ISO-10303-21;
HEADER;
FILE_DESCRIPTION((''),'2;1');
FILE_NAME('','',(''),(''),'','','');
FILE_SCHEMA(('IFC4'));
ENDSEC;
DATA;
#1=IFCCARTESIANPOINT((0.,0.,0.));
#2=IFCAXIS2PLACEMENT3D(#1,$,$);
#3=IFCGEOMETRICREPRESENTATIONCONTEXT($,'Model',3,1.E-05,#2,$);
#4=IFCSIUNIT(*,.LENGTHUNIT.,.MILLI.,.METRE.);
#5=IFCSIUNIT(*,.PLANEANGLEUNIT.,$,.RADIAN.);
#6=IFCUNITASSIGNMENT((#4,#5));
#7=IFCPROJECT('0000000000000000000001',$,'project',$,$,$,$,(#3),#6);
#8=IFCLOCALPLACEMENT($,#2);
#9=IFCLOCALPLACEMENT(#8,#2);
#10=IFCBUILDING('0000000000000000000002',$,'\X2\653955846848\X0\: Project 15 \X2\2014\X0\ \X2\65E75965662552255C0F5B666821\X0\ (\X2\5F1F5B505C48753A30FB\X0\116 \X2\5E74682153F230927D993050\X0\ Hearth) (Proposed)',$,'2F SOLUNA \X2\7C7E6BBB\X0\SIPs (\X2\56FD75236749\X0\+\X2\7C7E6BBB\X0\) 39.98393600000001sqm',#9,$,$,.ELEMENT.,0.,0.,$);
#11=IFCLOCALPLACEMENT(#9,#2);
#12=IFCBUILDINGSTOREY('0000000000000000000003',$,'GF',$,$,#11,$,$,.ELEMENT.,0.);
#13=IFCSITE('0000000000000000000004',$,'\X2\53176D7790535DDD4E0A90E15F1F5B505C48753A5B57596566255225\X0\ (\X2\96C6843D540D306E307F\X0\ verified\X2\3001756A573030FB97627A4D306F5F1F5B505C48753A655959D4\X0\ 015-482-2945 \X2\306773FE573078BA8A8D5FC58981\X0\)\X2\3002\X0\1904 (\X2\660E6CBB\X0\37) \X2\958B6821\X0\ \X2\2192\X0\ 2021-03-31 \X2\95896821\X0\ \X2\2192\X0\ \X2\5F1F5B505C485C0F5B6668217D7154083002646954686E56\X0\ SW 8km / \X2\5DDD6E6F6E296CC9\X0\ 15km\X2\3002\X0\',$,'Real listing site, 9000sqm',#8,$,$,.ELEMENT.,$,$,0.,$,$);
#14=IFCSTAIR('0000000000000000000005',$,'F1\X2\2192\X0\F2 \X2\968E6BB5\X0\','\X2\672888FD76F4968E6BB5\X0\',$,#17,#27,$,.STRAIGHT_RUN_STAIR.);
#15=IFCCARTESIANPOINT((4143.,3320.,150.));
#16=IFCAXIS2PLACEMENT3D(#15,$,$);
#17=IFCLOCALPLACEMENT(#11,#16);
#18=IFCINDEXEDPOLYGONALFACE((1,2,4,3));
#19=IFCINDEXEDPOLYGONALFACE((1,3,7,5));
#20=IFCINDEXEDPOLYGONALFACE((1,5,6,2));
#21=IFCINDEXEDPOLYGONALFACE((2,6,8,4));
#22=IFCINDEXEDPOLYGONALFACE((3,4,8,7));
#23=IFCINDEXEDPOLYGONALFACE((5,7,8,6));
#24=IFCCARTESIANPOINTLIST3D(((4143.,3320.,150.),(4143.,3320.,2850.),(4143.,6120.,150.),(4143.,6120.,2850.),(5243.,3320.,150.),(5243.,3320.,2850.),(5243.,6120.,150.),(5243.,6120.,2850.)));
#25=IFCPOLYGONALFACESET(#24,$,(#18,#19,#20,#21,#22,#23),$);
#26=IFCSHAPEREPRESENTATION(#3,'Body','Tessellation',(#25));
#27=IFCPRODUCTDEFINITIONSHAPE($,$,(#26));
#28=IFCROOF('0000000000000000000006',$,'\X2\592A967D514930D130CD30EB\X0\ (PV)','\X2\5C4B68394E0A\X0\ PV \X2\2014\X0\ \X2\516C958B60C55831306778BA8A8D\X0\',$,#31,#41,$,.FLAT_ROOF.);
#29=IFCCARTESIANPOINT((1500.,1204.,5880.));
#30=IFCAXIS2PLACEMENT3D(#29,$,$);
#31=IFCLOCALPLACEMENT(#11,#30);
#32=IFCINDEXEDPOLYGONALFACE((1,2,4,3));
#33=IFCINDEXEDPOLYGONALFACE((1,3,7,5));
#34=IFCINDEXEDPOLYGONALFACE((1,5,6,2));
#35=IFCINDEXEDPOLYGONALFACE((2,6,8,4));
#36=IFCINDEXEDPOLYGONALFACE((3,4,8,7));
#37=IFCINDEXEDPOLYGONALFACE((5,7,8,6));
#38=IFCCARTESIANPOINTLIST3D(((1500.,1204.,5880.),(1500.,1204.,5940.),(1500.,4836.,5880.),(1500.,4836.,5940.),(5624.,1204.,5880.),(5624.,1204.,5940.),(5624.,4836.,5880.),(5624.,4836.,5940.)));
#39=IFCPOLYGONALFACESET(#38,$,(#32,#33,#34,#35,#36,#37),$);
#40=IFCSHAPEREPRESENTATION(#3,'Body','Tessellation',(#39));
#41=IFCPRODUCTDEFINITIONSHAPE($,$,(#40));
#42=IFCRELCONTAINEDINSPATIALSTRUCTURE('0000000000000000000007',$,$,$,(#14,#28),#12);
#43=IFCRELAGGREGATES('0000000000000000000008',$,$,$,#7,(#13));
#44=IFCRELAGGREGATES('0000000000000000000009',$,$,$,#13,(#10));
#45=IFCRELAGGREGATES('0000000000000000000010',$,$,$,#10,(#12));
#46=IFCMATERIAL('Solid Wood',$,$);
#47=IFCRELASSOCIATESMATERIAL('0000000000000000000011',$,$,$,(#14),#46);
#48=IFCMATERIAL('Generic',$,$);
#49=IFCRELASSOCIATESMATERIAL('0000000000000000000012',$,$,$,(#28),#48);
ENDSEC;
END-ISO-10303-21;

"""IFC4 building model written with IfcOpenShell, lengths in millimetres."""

from ifc_helpers import new_model, si_unit, frame, frame_2d, origin, place, context, project, spatial, rectangle, extrude, material, element, save


model = new_model("IFC4")

# Units and contexts
model_context = context("Model", 3, precision=1e-05, world=origin())
ifc_project = project(units=[si_unit("LENGTHUNIT", "METRE", prefix="MILLI"), si_unit("PLANEANGLEUNIT", "RADIAN")], contexts=[model_context])

# Site, building, storey
site_placement = place(None, origin())
site = spatial("IfcSite", under=ifc_project, at=site_placement, Name="北海道川上郡弟子屈町字奥春別 (集落名のみ verified、番地・面積は弟子屈町教委 015-482-2945 で現地確認必要)。1904 (明治37) 開校 → 2021-03-31 閉校 → 弟子屈小学校統合。摩周湖 SW 8km / 川湯温泉 15km。", ObjectType="Real listing site, 9000sqm", CompositionType="ELEMENT", RefElevation=0.0)
building_placement = place(site_placement, origin())
building = spatial("IfcBuilding", under=site, at=building_placement, Name="改善案: Project 15 — 旧奥春別小学校 (弟子屈町・116 年校史を継ぐ Hearth) (Proposed)", ObjectType="2F SOLUNA 籾殻SIPs (国産杉+籾殻) 39.98393600000001sqm", CompositionType="ELEMENT", ElevationOfRefHeight=0.0, ElevationOfTerrain=0.0)
storey_placement = place(building_placement, origin())
storey = spatial("IfcBuildingStorey", under=building, at=storey_placement, Name="GF", CompositionType="ELEMENT", Elevation=0.0)

# Shared definitions
ifc_material_1 = material(Name="Generic")

# Stair
ifc_material_2 = material(Name="Solid Wood")
stair_placement = place(storey_placement, frame((4143.0, 3320.0, 150.0)))
element("IfcStair", 1, at=stair_placement, inside=storey, material=ifc_material_2, Name="F1→F2 階段", Description="木製直階段", PredefinedType="STRAIGHT_RUN_STAIR", context=model_context, shape_type="SweptSolid", body=[
    extrude(rectangle(XDim=1100.0, YDim=2800.0, at=frame_2d((550.0, 1400.0))), frame((4143.0, 3320.0, 150.0)), (0.0, 0.0, 1.0), 2700.0),
])

# Roof
roof_placement = place(storey_placement, frame((1500.0, 1204.0, 5880.0)))
element("IfcRoof", 2, at=roof_placement, inside=storey, material=ifc_material_1, Name="太陽光パネル (PV)", Description="屋根上 PV — 公開情報で確認", PredefinedType="FLAT_ROOF", context=model_context, shape_type="SweptSolid", body=[
    extrude(rectangle(XDim=4124.0, YDim=3632.0, at=frame_2d((2062.0, 1816.0))), frame((1500.0, 1204.0, 5880.0)), (0.0, 0.0, 1.0), 60.0),
])

save(model, "model.ifc")
